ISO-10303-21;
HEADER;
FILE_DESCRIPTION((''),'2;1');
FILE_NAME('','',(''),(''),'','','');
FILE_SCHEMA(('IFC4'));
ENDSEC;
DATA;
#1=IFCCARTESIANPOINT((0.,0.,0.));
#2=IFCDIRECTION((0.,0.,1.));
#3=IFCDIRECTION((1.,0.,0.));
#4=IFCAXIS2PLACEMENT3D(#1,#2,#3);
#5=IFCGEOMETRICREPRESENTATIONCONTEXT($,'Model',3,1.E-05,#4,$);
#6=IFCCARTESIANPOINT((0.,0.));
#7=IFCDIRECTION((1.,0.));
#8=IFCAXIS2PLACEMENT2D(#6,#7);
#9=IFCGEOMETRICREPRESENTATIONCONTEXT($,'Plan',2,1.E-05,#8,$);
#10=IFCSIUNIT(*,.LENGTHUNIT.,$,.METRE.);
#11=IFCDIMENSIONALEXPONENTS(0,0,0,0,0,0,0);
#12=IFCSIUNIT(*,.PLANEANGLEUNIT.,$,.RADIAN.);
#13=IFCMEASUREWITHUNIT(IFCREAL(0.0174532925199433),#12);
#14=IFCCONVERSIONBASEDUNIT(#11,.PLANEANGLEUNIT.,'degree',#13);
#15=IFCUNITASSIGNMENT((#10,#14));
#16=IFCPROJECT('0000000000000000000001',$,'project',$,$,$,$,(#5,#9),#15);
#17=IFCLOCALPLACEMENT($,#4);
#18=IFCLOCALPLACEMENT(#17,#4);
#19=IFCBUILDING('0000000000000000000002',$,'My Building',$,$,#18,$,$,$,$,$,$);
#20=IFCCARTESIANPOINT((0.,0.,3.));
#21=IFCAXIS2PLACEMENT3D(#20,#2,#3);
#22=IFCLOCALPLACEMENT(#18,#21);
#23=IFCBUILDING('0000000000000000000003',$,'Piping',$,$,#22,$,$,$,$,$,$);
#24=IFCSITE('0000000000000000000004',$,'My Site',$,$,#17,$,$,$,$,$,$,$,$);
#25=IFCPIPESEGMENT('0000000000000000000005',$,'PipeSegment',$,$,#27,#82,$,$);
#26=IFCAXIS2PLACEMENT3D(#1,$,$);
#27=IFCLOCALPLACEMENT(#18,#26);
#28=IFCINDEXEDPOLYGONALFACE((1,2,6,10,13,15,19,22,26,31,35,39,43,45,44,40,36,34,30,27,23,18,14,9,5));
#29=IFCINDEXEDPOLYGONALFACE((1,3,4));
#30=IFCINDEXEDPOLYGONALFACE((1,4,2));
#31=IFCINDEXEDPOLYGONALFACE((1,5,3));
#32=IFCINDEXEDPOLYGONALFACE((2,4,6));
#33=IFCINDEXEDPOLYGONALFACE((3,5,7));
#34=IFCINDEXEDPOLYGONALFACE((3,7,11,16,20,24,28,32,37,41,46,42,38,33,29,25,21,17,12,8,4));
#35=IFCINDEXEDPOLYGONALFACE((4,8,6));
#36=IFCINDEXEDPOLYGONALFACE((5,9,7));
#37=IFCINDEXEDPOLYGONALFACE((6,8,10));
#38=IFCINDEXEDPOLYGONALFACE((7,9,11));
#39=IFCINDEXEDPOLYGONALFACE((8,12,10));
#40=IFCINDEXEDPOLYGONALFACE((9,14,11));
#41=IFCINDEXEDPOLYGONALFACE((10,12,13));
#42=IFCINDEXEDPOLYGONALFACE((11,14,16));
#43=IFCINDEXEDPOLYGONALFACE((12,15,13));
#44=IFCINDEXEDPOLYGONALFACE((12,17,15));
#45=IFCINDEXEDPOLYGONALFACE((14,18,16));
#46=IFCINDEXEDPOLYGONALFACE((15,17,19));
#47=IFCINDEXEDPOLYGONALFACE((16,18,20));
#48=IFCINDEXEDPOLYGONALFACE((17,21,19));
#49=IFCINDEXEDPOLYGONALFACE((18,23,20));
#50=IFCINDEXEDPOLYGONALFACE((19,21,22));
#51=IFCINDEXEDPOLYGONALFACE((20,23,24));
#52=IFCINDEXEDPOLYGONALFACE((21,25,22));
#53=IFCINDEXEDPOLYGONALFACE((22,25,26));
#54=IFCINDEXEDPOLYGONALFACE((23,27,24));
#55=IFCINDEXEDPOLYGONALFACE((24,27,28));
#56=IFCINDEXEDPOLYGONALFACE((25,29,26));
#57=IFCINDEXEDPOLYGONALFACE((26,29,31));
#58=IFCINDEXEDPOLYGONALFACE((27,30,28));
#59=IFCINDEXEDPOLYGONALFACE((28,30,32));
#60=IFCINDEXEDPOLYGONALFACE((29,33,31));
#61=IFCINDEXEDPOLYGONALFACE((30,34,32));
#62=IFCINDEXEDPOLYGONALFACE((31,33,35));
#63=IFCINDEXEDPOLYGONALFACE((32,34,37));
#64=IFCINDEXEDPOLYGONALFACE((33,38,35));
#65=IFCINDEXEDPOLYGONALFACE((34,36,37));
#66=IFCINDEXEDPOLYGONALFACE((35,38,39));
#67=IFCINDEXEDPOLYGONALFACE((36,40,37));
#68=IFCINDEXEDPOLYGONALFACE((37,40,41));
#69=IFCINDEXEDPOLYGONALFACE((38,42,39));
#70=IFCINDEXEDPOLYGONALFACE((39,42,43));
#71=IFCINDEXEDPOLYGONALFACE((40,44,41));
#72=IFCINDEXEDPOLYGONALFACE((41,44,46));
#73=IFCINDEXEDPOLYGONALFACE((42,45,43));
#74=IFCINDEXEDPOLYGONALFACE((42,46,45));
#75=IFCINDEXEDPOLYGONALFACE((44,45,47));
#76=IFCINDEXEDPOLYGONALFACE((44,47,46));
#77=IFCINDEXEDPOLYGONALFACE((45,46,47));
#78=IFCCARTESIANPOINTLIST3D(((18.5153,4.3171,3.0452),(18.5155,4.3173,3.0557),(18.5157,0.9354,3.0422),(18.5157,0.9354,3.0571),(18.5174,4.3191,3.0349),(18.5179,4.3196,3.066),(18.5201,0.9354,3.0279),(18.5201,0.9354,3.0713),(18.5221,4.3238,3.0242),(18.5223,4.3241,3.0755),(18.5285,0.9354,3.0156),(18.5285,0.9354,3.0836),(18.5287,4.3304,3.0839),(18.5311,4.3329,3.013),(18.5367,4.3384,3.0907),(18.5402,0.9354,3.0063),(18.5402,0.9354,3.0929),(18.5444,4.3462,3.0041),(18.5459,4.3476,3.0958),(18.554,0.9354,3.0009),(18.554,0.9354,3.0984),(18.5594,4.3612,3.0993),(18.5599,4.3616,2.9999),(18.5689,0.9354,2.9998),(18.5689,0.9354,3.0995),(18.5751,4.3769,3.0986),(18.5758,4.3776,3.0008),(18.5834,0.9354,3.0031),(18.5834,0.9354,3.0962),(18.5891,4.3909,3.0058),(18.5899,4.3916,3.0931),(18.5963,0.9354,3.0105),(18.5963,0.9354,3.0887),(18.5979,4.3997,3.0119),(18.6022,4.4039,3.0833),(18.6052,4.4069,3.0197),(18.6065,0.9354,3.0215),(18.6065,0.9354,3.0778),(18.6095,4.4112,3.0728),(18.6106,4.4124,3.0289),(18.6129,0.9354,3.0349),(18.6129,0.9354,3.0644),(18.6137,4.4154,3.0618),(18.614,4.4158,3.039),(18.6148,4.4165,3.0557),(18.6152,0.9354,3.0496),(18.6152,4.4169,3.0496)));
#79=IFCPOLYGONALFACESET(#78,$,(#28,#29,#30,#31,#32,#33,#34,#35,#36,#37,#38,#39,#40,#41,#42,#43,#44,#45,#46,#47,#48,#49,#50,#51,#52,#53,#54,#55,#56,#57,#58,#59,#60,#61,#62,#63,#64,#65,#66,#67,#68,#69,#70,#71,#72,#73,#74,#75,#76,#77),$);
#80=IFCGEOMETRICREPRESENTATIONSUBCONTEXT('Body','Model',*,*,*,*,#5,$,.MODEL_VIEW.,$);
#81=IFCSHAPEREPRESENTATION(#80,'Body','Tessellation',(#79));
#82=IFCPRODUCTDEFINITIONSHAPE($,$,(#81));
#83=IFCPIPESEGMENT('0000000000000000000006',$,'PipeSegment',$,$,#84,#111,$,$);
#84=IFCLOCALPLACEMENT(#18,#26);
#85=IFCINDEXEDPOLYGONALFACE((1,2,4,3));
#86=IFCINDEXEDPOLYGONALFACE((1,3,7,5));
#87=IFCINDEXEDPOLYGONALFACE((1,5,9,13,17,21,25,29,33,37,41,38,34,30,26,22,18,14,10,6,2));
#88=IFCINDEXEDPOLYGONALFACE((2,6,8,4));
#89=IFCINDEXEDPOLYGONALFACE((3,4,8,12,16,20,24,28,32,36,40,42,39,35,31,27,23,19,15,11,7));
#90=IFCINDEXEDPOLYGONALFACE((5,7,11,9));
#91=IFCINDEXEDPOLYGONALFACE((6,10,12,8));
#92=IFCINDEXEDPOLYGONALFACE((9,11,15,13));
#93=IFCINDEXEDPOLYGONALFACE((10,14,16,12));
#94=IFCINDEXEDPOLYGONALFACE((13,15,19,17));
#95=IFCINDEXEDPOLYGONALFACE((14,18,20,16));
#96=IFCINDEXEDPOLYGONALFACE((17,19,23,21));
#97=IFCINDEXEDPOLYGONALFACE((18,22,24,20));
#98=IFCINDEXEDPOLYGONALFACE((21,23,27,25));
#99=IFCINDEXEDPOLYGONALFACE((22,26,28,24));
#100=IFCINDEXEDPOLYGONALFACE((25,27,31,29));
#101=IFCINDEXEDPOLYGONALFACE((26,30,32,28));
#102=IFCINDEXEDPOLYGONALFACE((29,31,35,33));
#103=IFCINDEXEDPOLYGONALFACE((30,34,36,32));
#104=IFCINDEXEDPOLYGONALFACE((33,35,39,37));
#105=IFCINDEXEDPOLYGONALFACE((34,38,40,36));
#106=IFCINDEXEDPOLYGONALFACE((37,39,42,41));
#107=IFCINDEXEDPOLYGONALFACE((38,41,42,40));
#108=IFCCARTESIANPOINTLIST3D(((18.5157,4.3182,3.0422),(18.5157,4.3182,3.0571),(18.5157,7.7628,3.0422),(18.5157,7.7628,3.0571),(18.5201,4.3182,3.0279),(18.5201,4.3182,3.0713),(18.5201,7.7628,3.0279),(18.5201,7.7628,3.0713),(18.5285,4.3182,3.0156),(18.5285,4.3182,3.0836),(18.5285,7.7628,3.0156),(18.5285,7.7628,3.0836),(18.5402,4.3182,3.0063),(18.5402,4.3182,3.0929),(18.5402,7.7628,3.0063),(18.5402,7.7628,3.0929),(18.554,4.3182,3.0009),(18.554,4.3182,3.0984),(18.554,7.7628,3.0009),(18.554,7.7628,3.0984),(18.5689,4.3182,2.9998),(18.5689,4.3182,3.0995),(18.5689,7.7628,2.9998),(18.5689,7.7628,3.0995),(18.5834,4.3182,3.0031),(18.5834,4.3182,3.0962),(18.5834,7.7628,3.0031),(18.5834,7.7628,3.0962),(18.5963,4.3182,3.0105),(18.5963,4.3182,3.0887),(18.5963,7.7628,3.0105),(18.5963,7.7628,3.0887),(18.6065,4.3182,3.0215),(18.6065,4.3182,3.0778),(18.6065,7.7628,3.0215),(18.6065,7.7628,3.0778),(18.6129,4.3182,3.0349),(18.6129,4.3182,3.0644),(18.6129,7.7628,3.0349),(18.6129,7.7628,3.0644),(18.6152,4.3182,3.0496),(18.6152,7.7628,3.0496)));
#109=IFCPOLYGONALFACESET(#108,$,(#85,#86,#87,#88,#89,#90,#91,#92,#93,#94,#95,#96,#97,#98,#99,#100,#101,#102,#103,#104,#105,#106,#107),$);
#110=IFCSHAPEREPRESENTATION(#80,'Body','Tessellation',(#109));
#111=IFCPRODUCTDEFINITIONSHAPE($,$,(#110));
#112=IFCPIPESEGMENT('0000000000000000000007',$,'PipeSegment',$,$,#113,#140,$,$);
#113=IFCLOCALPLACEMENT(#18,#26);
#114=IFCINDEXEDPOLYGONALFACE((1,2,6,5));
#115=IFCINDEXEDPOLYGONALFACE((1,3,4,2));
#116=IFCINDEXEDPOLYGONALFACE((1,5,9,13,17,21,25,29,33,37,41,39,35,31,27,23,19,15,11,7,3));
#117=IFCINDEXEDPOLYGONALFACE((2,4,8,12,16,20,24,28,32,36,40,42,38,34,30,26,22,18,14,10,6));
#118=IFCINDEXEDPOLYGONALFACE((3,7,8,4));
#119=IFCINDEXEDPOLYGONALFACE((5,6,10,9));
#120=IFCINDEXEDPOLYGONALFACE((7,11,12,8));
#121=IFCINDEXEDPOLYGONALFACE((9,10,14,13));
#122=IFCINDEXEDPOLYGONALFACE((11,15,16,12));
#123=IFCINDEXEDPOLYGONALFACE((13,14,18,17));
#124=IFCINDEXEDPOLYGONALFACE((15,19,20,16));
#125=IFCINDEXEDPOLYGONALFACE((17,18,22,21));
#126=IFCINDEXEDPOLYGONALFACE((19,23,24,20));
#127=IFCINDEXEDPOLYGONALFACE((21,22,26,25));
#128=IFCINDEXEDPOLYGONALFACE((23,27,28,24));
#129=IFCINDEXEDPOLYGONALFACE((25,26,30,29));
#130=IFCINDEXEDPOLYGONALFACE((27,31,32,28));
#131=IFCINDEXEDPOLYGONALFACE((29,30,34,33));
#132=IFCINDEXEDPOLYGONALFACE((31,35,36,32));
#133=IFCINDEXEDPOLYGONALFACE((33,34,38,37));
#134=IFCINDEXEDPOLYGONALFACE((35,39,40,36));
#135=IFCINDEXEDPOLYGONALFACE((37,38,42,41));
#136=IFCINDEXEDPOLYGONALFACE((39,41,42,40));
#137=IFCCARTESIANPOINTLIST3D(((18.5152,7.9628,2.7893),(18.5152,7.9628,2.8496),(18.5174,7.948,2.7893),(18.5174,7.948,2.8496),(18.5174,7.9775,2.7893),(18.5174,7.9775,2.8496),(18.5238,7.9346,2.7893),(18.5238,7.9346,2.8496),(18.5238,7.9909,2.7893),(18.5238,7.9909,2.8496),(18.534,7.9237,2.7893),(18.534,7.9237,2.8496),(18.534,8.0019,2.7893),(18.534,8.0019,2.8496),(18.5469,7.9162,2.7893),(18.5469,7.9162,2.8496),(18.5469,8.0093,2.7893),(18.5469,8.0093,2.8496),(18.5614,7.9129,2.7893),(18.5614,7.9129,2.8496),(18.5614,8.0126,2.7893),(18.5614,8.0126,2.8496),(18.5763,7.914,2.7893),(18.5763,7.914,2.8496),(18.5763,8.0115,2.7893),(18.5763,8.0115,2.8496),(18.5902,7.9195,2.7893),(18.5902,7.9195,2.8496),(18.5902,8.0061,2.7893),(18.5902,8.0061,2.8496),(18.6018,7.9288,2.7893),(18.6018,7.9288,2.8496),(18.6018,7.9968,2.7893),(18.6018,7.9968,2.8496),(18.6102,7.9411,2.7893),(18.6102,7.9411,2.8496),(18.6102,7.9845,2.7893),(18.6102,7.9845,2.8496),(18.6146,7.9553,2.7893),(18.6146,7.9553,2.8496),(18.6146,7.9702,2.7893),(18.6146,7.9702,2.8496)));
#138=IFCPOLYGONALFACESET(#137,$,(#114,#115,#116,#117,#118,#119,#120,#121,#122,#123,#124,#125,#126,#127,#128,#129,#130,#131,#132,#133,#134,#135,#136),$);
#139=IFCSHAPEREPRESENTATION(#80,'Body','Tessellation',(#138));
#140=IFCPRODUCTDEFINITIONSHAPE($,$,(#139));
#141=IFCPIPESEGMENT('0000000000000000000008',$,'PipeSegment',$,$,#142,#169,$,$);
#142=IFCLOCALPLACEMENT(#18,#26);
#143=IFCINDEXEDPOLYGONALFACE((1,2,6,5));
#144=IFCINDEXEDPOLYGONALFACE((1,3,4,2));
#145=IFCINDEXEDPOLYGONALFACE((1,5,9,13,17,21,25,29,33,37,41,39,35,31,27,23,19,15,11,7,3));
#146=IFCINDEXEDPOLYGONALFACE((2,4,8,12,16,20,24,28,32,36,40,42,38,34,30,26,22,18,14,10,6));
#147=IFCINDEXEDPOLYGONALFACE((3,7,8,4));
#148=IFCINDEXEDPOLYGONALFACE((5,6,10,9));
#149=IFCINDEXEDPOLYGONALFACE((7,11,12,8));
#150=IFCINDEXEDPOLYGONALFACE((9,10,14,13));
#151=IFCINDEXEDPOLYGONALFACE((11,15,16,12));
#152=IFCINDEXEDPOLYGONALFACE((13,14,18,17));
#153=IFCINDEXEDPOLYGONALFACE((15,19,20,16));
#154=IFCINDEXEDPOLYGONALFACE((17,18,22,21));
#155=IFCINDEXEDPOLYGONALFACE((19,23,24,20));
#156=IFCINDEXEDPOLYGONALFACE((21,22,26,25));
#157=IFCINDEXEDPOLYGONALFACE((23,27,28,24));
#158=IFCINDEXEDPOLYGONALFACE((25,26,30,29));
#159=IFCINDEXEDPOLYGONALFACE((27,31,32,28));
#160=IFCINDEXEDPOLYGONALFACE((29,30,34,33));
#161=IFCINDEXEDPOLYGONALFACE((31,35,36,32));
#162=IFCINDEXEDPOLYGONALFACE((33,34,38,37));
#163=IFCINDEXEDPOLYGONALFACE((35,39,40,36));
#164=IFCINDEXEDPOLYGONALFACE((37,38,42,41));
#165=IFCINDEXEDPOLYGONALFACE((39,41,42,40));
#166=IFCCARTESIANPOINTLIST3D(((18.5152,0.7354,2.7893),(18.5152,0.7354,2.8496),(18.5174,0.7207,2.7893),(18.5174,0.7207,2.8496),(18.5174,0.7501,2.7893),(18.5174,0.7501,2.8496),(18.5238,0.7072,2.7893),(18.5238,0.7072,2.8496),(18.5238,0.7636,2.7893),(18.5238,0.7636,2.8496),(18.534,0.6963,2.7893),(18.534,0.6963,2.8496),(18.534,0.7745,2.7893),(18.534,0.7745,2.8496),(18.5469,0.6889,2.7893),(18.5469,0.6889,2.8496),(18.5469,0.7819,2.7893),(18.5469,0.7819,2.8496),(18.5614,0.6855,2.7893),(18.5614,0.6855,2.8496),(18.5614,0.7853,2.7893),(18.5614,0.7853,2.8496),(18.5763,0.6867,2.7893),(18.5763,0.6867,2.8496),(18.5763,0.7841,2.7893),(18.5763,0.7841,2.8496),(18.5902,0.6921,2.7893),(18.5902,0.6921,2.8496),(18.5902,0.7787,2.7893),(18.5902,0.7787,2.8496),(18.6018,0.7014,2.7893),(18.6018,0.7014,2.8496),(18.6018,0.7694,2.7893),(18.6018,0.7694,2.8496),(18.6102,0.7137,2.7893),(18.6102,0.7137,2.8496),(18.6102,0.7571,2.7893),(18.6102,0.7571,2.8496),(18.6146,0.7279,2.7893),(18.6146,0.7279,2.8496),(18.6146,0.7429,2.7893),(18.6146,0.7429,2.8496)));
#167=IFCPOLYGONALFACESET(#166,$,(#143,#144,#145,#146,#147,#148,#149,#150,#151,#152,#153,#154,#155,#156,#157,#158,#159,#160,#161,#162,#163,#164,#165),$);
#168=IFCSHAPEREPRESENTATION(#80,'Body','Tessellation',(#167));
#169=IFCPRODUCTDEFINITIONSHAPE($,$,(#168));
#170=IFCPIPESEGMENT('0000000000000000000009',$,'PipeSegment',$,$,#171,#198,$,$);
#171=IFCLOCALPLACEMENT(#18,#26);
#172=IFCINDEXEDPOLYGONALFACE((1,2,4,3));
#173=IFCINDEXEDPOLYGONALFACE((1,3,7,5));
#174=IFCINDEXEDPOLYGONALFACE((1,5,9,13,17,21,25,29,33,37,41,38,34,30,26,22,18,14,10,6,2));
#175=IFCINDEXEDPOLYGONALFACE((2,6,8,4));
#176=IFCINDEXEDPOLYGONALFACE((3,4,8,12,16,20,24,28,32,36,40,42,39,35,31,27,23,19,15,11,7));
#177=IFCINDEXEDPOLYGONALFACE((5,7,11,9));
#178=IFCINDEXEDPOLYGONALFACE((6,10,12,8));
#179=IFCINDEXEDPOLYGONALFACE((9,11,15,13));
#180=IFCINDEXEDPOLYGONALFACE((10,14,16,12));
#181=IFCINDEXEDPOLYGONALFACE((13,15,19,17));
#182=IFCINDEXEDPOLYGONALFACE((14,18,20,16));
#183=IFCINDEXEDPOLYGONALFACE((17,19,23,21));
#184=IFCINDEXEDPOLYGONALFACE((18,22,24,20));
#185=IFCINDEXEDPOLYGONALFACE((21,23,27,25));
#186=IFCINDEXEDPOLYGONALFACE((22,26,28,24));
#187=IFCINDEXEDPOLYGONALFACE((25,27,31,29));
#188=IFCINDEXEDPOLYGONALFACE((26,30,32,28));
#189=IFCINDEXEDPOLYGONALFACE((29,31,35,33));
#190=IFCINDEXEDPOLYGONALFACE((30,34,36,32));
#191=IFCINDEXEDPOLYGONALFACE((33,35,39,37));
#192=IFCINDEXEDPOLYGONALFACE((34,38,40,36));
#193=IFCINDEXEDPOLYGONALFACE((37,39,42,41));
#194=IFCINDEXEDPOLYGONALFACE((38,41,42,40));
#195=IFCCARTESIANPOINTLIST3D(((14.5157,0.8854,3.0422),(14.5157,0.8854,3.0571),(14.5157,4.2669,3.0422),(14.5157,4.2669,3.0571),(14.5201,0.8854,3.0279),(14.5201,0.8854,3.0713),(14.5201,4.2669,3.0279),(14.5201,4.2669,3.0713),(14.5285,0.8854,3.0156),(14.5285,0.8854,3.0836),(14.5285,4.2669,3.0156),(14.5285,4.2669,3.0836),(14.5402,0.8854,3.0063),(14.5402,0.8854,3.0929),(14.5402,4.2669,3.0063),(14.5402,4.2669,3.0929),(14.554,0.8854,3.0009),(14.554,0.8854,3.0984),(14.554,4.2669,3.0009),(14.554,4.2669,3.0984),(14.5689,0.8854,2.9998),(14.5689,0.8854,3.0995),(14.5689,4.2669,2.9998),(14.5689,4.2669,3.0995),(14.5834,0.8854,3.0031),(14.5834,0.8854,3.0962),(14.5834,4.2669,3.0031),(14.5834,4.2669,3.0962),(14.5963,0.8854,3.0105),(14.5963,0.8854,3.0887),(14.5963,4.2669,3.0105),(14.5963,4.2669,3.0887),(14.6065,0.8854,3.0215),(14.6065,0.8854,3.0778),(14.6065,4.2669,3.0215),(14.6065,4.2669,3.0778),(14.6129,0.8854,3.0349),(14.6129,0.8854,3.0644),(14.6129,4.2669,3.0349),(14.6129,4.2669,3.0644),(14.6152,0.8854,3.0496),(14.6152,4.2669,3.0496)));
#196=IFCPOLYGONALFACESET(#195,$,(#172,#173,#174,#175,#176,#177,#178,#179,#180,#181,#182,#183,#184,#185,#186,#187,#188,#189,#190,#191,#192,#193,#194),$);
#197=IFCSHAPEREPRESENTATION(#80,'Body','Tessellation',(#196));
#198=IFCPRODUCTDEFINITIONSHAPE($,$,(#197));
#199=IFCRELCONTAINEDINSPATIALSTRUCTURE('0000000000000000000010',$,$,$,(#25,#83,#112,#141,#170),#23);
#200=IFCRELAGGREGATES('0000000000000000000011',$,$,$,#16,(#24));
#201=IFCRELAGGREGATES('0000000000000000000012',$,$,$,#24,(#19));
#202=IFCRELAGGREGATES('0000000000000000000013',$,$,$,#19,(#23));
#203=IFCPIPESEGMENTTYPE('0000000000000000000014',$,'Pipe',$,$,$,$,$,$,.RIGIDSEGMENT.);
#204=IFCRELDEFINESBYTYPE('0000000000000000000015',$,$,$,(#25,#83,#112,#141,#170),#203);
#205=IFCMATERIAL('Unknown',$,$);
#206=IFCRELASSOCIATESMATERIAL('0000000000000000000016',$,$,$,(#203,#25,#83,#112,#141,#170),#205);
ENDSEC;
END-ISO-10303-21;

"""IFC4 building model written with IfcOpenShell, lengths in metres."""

from ifc_helpers import new_model, entity, si_unit, converted_unit, frame, origin_with_axes, origin_2d_with_axis, place, context, subcontext, project, spatial, circle, extrude, clip, halfspace, material, material_profile, profile_set, profile_usage, type_object, element, save


model = new_model("IFC4")

# Units and contexts
model_context = context("Model", 3, precision=1e-05, world=origin_with_axes())
plan_context = context("Plan", 2, precision=1e-05, world=origin_2d_with_axis())
body_context = subcontext(model_context, "Body", "Model", "MODEL_VIEW")
ifc_project = project(units=[si_unit("LENGTHUNIT", "METRE"), converted_unit("PLANEANGLEUNIT", "degree", entity("IfcReal", 0.0174532925199433), si_unit("PLANEANGLEUNIT", "RADIAN"), dimensions=[0, 0, 0, 0, 0, 0, 0])], contexts=[model_context, plan_context])

# Site, buildings
site_placement = place(None, origin_with_axes())
site = spatial("IfcSite", under=ifc_project, at=site_placement, Name="My Site")
building_1_placement = place(site_placement, origin_with_axes())
building_1 = spatial("IfcBuilding", under=site, at=building_1_placement, Name="My Building")
building_2_placement = place(building_1_placement, frame((0.0, 0.0, 3.0), z_axis=(0.0, 0.0, 1.0), x_axis=(1.0, 0.0, 0.0)))
building_2 = spatial("IfcBuilding", under=building_1, at=building_2_placement, Name="Piping")

# Pipe segments
ifc_material = material(Name="Unknown")
ifc_material_profile_1 = material_profile(ifc_material, circle(Radius=0.05))
ifc_profile_set_1 = profile_set([ifc_material_profile_1])
pipe_segment_type = type_object("IfcPipeSegmentType", Name="Pipe", PredefinedType="RIGIDSEGMENT", material=ifc_profile_set_1)
ifc_profile_usage_1 = profile_usage(ifc_profile_set_1, cardinal=5)
pipe_segment_1_placement = place(building_2_placement, frame((18.5652, 4.4169, 0.0496), z_axis=(0.0, -1.0, 0.0), x_axis=(1.0, 0.0, 0.0)))
element("IfcPipeSegment", 1, at=pipe_segment_1_placement, inside=building_2, type_object=pipe_segment_type, material=ifc_profile_usage_1, Name="PipeSegment", context=body_context, shape_type="Clipping", body=[
    clip(extrude(circle(Radius=0.05), origin_with_axes(), (0.0, 0.0, 1.0), 3.4815), halfspace(frame((0.05, -3.0496, 0.0), z_axis=(-0.707114, 0.0, -0.7071), x_axis=(0.0, 1.0, 0.0)), False)),
])
ifc_profile_usage_2 = profile_usage(ifc_profile_set_1, cardinal=5)
pipe_segment_2_placement = place(building_2_placement, frame((18.5652, 4.3182, 0.0496), z_axis=(0.0, 1.0, 0.0), x_axis=(1.0, 0.0, 0.0)))
element("IfcPipeSegment", 2, at=pipe_segment_2_placement, inside=building_2, type_object=pipe_segment_type, material=ifc_profile_usage_2, Name="PipeSegment", context=body_context, shape_type="SweptSolid", body=[
    extrude(circle(Radius=0.05), origin_with_axes(), (0.0, 0.0, 1.0), 3.4446),
])
ifc_profile_usage_3 = profile_usage(ifc_profile_set_1, cardinal=5)
pipe_segment_3_placement = place(building_2_placement, frame((18.5652, 7.9628, -0.1504), z_axis=(0.0, 0.0, -1.0), x_axis=(-1.0, 0.0, 0.0)))
element("IfcPipeSegment", 3, at=pipe_segment_3_placement, inside=building_2, type_object=pipe_segment_type, material=ifc_profile_usage_3, Name="PipeSegment", context=body_context, shape_type="SweptSolid", body=[
    extrude(circle(Radius=0.05), origin_with_axes(), (0.0, 0.0, 1.0), 0.0604),
])
ifc_profile_usage_4 = profile_usage(ifc_profile_set_1, cardinal=5)
pipe_segment_4_placement = place(building_2_placement, frame((18.5652, 0.7354, -0.1504), z_axis=(0.0, 0.0, -1.0), x_axis=(-1.0, 0.0, 0.0)))
element("IfcPipeSegment", 4, at=pipe_segment_4_placement, inside=building_2, type_object=pipe_segment_type, material=ifc_profile_usage_4, Name="PipeSegment", context=body_context, shape_type="SweptSolid", body=[
    extrude(circle(Radius=0.05), origin_with_axes(), (0.0, 0.0, 1.0), 0.0604),
])
ifc_profile_usage_5 = profile_usage(ifc_profile_set_1, cardinal=5)
pipe_segment_5_placement = place(building_2_placement, frame((14.5652, 0.8854, 0.0496), z_axis=(0.0, 1.0, 0.000001), x_axis=(1.0, 0.0, 0.0)))
element("IfcPipeSegment", 5, at=pipe_segment_5_placement, inside=building_2, type_object=pipe_segment_type, material=ifc_profile_usage_5, Name="PipeSegment", context=body_context, shape_type="SweptSolid", body=[
    extrude(circle(Radius=0.05), origin_with_axes(), (0.0, 0.0, 1.0), 3.3815),
])

save(model, "model.ifc")
